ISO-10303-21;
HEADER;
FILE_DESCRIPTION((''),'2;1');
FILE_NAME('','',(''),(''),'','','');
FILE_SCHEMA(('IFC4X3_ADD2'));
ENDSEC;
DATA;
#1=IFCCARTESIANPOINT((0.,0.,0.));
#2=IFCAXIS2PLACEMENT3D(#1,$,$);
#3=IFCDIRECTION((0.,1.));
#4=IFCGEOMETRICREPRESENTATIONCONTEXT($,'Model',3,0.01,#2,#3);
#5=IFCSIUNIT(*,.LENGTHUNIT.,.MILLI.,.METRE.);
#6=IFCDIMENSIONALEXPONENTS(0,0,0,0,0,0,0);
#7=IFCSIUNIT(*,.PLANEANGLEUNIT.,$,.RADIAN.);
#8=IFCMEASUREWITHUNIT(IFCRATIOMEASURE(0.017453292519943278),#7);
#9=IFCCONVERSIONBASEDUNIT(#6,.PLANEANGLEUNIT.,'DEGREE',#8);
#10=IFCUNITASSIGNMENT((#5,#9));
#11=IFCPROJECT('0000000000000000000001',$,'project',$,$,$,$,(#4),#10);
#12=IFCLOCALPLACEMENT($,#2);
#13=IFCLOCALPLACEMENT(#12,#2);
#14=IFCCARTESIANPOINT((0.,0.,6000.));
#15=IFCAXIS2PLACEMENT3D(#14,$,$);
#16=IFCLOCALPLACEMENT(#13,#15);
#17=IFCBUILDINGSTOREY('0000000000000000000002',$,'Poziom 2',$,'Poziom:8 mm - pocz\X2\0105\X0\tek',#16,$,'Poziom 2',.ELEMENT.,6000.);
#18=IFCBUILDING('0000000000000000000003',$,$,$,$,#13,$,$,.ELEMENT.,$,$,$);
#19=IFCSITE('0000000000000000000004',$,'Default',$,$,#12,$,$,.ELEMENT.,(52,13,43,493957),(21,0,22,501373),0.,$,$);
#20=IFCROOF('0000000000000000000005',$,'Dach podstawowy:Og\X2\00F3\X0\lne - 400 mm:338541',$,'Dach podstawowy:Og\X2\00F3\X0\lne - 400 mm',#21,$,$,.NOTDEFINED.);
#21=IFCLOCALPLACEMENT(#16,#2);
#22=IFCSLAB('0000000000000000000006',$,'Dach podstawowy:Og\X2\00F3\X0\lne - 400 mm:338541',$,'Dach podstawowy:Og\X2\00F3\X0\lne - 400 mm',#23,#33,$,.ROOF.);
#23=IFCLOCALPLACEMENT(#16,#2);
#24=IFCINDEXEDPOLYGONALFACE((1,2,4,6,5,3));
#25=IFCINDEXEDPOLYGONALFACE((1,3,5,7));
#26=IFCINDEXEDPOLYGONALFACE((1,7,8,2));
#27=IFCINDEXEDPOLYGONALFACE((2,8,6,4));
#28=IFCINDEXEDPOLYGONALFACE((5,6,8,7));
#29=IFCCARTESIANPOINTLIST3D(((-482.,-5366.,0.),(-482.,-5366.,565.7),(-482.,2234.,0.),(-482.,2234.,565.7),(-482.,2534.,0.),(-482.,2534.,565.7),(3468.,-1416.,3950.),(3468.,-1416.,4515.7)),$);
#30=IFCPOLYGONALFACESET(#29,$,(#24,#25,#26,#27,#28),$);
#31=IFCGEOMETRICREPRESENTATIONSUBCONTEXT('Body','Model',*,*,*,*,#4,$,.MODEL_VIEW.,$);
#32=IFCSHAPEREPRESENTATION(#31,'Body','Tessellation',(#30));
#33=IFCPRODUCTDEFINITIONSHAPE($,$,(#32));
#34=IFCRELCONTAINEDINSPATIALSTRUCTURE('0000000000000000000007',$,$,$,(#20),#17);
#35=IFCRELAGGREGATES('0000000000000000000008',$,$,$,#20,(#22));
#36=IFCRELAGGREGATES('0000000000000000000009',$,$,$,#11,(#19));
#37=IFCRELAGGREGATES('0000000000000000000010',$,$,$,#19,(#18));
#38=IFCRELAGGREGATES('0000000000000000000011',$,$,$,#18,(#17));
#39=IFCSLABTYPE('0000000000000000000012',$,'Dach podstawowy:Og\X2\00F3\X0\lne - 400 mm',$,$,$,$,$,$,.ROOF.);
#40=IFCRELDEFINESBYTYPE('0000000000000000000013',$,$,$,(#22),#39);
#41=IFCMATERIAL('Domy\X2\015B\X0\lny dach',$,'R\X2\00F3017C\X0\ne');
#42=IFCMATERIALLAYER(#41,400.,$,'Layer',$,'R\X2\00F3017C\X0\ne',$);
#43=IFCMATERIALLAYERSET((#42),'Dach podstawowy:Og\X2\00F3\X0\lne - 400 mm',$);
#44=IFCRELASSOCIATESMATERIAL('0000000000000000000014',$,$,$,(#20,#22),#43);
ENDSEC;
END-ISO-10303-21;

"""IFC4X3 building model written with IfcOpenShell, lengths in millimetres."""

from ifc_helpers import new_model, entity, si_unit, converted_unit, direction, frame, origin, place, context, subcontext, project, spatial, polyline, outline, extrude, material, layer, layer_set, type_object, element, aggregate, save


model = new_model("IFC4X3")

# Units and contexts
model_context = context("Model", 3, precision=0.01, world=origin(), true_north=direction((0.0, 1.0)))
body_context = subcontext(model_context, "Body", "Model", "MODEL_VIEW")
ifc_project = project(units=[si_unit("LENGTHUNIT", "METRE", prefix="MILLI"), converted_unit("PLANEANGLEUNIT", "DEGREE", entity("IfcRatioMeasure", 0.017453292519943278), si_unit("PLANEANGLEUNIT", "RADIAN"), dimensions=[0, 0, 0, 0, 0, 0, 0])], contexts=[model_context])

# Site, building, storey
site_placement = place(None, origin())
site = spatial("IfcSite", under=ifc_project, at=site_placement, Name="Default", CompositionType="ELEMENT", RefLatitude=(52, 13, 43, 493957), RefLongitude=(21, 0, 22, 501373), RefElevation=0.0)
building_placement = place(site_placement, origin())
building = spatial("IfcBuilding", under=site, at=building_placement, CompositionType="ELEMENT")
storey_placement = place(building_placement, frame((0.0, 0.0, 6000.0)))
storey = spatial("IfcBuildingStorey", under=building, at=storey_placement, Name="Poziom 2", ObjectType="Poziom:8 mm - początek", LongName="Poziom 2", CompositionType="ELEMENT", Elevation=6000.0)

# Roof, slab
ifc_material = material(Name="Domyślny dach", Category="Różne")
ifc_layer = layer(ifc_material, 400.0, Name="Layer", Category="Różne")
ifc_layer_set = layer_set([ifc_layer], Name="Dach podstawowy:Ogólne - 400 mm")
roof_placement = place(storey_placement, frame((-482.0, -5366.0, 0.0)))
roof = element("IfcRoof", 1, at=roof_placement, inside=storey, material=ifc_layer_set, Name="Dach podstawowy:Ogólne - 400 mm:338541", ObjectType="Dach podstawowy:Ogólne - 400 mm", PredefinedType="NOTDEFINED")
slab_type = type_object("IfcSlabType", Name="Dach podstawowy:Ogólne - 400 mm", PredefinedType="ROOF")
slab_1_placement = place(roof_placement, origin())
slab_1 = element("IfcSlab", 2, at=slab_1_placement, type_object=slab_type, material=ifc_layer_set, Name="Dach podstawowy:Ogólne - 400 mm:338541", ObjectType="Dach podstawowy:Ogólne - 400 mm", PredefinedType="ROOF", context=body_context, shape_type="SweptSolid", body=[
    extrude(outline(polyline([(-2793.1, 3650.0), (-2793.1, -3950.0), (2793.1, 0.0), (-2793.1, 3950.0), (-2793.1, 3650.0)])), frame((1975.0, 3950.0, 1975.0), z_axis=(-0.707107, 0.0, 0.707107), x_axis=(0.707107, 0.0, 0.707107)), (0.707107, 0.0, 0.707107), 565.7),
])
aggregate(roof, [slab_1])

save(model, "model.ifc")
